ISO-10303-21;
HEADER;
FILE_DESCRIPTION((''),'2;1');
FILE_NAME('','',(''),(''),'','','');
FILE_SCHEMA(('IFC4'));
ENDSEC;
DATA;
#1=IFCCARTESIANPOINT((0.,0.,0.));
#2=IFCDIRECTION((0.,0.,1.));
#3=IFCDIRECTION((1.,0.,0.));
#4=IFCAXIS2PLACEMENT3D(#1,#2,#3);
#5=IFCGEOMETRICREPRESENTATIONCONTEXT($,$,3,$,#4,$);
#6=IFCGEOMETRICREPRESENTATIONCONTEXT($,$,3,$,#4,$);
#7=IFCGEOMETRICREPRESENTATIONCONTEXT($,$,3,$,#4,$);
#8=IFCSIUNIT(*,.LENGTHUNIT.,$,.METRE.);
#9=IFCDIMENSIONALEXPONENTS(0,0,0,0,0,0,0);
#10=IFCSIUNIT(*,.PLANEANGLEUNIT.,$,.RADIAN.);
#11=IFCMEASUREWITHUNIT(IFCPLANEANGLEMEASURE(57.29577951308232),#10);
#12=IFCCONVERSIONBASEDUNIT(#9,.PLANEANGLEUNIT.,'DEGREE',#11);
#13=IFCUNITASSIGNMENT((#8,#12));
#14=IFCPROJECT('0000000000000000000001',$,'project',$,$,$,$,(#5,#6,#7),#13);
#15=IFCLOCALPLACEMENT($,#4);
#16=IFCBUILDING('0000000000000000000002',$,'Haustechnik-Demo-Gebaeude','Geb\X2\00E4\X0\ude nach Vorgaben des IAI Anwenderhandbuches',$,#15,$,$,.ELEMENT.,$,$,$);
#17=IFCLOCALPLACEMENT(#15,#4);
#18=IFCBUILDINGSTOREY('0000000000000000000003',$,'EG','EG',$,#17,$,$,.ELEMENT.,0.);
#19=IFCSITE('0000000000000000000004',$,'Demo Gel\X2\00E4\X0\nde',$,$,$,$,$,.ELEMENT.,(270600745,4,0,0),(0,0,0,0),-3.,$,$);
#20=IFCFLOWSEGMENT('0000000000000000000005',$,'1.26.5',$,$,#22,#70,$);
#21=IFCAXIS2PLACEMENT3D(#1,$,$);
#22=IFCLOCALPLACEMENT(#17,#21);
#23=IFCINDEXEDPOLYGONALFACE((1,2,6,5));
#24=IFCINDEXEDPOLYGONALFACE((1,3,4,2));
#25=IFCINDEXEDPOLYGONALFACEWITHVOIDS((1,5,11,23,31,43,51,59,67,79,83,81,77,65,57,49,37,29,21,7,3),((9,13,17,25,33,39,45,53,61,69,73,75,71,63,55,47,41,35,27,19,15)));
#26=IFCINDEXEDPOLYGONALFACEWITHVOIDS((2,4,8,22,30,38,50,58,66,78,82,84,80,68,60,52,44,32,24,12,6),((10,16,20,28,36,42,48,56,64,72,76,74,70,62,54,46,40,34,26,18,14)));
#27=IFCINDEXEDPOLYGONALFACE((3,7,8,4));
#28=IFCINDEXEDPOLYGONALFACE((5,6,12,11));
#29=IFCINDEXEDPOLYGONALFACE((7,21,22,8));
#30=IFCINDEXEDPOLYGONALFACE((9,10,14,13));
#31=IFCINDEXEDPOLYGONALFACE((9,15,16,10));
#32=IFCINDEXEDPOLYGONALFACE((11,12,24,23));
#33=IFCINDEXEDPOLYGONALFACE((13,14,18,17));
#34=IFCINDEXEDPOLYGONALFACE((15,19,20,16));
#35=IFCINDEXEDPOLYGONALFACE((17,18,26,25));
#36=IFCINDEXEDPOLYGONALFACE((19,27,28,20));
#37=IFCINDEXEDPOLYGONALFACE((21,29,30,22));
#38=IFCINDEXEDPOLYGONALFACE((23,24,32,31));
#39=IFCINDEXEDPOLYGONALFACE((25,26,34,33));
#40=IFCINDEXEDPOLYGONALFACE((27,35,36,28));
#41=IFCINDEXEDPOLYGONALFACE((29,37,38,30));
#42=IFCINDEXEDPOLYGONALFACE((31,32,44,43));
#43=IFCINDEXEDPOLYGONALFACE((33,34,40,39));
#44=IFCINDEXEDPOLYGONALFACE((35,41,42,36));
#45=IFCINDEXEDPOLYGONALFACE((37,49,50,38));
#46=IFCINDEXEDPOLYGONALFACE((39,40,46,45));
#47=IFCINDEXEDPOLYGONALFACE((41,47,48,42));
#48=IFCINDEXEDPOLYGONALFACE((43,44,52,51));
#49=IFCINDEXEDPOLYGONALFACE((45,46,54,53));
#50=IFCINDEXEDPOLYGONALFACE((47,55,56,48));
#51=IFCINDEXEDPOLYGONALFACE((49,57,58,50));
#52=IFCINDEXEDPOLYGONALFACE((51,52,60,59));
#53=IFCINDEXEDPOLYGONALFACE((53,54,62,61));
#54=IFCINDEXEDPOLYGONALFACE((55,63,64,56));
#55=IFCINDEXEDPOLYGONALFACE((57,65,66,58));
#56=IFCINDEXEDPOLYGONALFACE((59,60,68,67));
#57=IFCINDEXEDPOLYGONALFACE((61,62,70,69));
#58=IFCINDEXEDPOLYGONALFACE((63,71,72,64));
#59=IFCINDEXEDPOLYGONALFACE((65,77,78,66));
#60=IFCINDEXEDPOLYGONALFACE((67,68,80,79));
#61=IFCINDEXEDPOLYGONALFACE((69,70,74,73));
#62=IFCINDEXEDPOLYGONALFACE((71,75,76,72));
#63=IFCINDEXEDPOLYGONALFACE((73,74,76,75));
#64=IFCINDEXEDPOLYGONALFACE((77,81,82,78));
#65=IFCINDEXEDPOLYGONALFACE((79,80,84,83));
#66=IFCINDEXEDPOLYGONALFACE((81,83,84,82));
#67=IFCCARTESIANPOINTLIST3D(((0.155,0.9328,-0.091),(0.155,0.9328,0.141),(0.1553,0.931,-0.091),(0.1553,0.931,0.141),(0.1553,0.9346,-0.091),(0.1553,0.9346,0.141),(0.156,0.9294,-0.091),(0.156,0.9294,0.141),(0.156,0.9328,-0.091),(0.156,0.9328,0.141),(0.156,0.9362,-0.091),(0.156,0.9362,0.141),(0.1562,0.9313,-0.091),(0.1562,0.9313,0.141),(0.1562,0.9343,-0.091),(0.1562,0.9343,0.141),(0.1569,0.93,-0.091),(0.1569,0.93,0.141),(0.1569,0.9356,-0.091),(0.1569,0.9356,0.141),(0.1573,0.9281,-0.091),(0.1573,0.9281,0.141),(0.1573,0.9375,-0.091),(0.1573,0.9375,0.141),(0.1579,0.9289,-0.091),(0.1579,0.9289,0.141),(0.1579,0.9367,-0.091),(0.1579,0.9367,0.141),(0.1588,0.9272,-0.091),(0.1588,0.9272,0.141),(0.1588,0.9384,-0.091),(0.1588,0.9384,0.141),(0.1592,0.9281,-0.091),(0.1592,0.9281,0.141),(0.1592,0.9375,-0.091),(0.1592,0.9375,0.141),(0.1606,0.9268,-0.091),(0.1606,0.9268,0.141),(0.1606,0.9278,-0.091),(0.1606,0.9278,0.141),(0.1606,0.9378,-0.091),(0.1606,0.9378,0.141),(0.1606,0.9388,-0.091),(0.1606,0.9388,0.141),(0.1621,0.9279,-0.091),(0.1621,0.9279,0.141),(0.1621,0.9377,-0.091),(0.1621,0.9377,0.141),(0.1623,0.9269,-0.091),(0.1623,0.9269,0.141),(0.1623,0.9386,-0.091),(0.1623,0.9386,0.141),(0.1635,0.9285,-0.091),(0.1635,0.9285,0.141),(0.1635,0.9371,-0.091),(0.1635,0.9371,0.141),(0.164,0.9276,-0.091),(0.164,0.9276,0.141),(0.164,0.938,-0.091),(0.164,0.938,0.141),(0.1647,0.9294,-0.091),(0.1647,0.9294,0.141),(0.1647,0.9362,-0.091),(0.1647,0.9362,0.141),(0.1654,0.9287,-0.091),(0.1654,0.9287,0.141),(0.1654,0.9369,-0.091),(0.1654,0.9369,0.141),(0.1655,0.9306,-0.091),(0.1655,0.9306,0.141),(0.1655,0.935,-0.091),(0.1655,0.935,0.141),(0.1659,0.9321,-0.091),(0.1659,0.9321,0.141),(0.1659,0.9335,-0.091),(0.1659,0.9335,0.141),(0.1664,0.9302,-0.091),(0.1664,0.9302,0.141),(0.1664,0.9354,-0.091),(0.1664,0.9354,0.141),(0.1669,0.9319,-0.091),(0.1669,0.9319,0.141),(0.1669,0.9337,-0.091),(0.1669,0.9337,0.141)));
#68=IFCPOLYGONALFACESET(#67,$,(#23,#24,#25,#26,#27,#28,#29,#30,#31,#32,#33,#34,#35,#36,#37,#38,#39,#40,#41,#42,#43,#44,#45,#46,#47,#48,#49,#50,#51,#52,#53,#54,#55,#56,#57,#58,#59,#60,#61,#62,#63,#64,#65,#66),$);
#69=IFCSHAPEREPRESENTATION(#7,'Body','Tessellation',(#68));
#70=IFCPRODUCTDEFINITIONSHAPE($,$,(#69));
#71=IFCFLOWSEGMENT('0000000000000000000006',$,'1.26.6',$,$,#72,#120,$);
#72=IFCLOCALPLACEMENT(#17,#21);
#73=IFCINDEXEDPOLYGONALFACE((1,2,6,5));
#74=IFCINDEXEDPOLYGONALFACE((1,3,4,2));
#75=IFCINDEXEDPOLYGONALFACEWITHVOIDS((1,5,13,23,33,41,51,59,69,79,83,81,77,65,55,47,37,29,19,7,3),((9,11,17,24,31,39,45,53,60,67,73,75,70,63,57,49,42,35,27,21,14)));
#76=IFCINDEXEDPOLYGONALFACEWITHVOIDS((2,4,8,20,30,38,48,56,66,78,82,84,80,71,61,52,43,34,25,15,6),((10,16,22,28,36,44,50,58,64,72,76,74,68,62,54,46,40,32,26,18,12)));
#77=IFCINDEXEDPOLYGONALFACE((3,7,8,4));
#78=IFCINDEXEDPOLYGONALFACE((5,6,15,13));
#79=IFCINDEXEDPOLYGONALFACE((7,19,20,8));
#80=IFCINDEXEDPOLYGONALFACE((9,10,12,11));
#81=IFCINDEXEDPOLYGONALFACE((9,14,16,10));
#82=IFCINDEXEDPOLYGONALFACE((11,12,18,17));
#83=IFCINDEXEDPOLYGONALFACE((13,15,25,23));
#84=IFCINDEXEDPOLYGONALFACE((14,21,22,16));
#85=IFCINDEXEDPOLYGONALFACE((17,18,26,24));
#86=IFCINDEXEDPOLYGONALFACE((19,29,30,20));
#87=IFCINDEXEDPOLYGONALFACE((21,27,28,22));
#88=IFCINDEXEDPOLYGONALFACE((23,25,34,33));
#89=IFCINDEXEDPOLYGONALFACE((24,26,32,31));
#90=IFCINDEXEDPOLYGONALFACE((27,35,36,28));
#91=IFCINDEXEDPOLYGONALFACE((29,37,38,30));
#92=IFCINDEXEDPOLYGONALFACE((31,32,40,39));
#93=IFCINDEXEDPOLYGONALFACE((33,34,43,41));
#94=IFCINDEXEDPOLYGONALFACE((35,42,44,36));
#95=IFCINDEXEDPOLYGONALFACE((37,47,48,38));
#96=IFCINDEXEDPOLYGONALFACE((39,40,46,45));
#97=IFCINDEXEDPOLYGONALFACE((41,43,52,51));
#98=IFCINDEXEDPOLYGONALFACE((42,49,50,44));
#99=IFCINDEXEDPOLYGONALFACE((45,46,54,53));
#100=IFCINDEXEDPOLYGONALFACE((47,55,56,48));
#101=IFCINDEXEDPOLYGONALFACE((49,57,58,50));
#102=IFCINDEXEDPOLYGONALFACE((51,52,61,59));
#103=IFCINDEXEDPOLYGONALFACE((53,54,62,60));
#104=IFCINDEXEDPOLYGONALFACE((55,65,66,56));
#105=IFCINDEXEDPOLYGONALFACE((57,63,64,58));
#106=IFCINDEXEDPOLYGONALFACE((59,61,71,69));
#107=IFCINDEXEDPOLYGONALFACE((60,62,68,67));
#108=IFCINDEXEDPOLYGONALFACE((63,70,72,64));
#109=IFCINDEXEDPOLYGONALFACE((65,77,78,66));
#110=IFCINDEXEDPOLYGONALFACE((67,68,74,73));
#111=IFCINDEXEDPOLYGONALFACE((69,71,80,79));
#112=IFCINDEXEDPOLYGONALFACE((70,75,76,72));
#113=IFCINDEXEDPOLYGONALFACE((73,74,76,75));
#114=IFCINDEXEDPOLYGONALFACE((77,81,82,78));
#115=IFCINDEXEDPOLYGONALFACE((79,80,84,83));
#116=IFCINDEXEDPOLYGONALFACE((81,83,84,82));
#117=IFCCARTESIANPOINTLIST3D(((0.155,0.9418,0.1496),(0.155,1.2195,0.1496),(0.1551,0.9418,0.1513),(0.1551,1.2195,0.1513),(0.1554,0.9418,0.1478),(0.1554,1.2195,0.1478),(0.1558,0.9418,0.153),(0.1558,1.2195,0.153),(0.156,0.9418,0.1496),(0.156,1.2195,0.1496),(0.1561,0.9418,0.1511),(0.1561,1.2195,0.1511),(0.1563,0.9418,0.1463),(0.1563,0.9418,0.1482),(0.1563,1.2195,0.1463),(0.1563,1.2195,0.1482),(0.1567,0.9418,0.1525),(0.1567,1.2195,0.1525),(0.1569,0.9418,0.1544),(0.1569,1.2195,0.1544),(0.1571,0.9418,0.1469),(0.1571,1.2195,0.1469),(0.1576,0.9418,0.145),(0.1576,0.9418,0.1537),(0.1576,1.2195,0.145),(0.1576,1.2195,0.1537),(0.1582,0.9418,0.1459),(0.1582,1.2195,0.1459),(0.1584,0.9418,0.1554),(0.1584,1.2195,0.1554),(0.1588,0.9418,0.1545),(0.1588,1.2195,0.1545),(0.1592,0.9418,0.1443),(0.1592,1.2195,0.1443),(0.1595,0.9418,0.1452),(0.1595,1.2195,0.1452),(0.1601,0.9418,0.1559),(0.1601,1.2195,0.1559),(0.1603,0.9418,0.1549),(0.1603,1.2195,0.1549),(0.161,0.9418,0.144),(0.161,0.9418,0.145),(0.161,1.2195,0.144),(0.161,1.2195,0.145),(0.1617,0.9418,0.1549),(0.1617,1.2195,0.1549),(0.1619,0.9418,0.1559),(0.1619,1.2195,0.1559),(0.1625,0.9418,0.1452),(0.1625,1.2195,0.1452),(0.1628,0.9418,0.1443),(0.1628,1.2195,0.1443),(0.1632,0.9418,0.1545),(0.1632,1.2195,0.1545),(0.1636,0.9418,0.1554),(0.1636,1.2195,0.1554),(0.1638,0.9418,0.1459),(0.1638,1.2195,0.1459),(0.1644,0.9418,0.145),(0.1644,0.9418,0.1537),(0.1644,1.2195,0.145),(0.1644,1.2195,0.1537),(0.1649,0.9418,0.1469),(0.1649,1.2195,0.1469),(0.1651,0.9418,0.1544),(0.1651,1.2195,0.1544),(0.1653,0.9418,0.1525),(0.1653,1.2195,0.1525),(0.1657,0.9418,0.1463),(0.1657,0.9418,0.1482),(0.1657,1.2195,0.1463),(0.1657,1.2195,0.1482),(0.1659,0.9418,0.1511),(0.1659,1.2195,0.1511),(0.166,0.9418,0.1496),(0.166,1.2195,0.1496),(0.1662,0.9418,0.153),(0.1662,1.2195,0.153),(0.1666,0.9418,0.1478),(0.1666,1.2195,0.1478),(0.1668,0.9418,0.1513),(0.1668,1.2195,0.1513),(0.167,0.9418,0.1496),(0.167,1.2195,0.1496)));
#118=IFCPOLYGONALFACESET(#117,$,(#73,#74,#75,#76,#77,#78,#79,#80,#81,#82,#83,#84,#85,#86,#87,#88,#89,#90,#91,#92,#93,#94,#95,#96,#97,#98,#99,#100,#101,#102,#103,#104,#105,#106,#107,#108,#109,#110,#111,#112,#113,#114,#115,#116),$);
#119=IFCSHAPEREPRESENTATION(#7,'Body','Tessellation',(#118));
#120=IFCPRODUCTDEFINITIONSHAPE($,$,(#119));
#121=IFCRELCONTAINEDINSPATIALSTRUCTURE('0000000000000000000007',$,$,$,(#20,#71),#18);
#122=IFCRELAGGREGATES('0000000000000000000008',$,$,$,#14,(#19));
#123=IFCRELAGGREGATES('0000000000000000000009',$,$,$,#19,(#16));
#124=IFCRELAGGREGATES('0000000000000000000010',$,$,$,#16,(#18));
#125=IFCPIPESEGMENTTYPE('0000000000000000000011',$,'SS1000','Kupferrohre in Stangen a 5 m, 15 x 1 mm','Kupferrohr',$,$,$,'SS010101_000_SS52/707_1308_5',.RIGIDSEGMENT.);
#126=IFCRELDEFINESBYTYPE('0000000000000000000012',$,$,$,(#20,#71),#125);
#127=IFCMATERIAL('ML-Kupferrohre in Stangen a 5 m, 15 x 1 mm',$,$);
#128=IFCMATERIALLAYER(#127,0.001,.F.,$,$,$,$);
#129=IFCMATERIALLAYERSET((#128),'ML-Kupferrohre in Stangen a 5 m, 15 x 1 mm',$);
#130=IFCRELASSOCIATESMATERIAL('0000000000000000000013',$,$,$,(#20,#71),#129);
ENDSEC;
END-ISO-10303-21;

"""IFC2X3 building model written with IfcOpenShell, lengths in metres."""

from ifc_helpers import new_model, entity, si_unit, converted_unit, frame, origin_with_axes, origin_2d_with_axis, place, context, project, spatial, hollow_circle, extrude, material, layer, layer_set, layer_usage, type_object, element, save


model = new_model("IFC2X3")

# Units and contexts
context_of_model_1 = context(None, 3, world=origin_with_axes())
context_of_model_2 = context(None, 3, world=origin_with_axes())
context_of_model_3 = context(None, 3, world=origin_with_axes())
ifc_project = project(units=[si_unit("LENGTHUNIT", "METRE"), converted_unit("PLANEANGLEUNIT", "DEGREE", entity("IfcPlaneAngleMeasure", 57.29577951308232), si_unit("PLANEANGLEUNIT", "RADIAN"), dimensions=[0, 0, 0, 0, 0, 0, 0])], contexts=[context_of_model_1, context_of_model_2, context_of_model_3])

# Site, building, storey
site = spatial("IfcSite", under=ifc_project, Name="Demo Gelände", CompositionType="ELEMENT", RefLatitude=(270600745, 4, 0, 0), RefLongitude=(0, 0, 0, 0), RefElevation=-3.0)
building_placement = place(None, origin_with_axes())
building = spatial("IfcBuilding", under=site, at=building_placement, Name="Haustechnik-Demo-Gebaeude", Description="Gebäude nach Vorgaben des IAI Anwenderhandbuches", CompositionType="ELEMENT")
storey_placement = place(building_placement, origin_with_axes())
storey = spatial("IfcBuildingStorey", under=building, at=storey_placement, Name="EG", Description="EG", CompositionType="ELEMENT", Elevation=0.0)

# Flow segments
ifc_material = material(Name="ML-Kupferrohre in Stangen a 5 m, 15 x 1 mm")
ifc_layer = layer(ifc_material, 0.001, ventilated=False)
ifc_layer_set = layer_set([ifc_layer], Name="ML-Kupferrohre in Stangen a 5 m, 15 x 1 mm")
ifc_layer_usage = layer_usage(ifc_layer_set, "AXIS2", "POSITIVE", 0.0)
pipe_segment_type_1 = type_object("IfcPipeSegmentType", Name="SS1000", Description="Kupferrohre in Stangen a 5 m, 15 x 1 mm", ApplicableOccurrence="Kupferrohr", ElementType="SS010101_000_SS52/707_1308_5", PredefinedType="RIGIDSEGMENT")
flow_segment_1_placement = place(storey_placement, frame((0.161, 0.9328, -0.091), z_axis=(0.0, 0.0, 1.0), x_axis=(-1.0, 0.0, 0.0)))
element("IfcFlowSegment", 1, at=flow_segment_1_placement, inside=storey, type_object=pipe_segment_type_1, material=ifc_layer_usage, Name="1.26.5", context=context_of_model_3, shape_type="SweptSolid", body=[
    extrude(hollow_circle(Radius=0.006, WallThickness=0.001, at=origin_2d_with_axis()), origin_with_axes(), (0.0, 0.0, 1.0), 0.232),
])
flow_segment_2_placement = place(storey_placement, frame((0.161, 0.9418, 0.15), z_axis=(0.0, 1.0, 0.0), x_axis=(0.0, 0.0, -1.0)))
element("IfcFlowSegment", 2, at=flow_segment_2_placement, inside=storey, type_object=pipe_segment_type_1, material=ifc_layer_usage, Name="1.26.6", context=context_of_model_3, shape_type="SweptSolid", body=[
    extrude(hollow_circle(Radius=0.006, WallThickness=0.001, at=origin_2d_with_axis()), origin_with_axes(), (0.0, 0.0, 1.0), 0.2777),
])

save(model, "model.ifc")
